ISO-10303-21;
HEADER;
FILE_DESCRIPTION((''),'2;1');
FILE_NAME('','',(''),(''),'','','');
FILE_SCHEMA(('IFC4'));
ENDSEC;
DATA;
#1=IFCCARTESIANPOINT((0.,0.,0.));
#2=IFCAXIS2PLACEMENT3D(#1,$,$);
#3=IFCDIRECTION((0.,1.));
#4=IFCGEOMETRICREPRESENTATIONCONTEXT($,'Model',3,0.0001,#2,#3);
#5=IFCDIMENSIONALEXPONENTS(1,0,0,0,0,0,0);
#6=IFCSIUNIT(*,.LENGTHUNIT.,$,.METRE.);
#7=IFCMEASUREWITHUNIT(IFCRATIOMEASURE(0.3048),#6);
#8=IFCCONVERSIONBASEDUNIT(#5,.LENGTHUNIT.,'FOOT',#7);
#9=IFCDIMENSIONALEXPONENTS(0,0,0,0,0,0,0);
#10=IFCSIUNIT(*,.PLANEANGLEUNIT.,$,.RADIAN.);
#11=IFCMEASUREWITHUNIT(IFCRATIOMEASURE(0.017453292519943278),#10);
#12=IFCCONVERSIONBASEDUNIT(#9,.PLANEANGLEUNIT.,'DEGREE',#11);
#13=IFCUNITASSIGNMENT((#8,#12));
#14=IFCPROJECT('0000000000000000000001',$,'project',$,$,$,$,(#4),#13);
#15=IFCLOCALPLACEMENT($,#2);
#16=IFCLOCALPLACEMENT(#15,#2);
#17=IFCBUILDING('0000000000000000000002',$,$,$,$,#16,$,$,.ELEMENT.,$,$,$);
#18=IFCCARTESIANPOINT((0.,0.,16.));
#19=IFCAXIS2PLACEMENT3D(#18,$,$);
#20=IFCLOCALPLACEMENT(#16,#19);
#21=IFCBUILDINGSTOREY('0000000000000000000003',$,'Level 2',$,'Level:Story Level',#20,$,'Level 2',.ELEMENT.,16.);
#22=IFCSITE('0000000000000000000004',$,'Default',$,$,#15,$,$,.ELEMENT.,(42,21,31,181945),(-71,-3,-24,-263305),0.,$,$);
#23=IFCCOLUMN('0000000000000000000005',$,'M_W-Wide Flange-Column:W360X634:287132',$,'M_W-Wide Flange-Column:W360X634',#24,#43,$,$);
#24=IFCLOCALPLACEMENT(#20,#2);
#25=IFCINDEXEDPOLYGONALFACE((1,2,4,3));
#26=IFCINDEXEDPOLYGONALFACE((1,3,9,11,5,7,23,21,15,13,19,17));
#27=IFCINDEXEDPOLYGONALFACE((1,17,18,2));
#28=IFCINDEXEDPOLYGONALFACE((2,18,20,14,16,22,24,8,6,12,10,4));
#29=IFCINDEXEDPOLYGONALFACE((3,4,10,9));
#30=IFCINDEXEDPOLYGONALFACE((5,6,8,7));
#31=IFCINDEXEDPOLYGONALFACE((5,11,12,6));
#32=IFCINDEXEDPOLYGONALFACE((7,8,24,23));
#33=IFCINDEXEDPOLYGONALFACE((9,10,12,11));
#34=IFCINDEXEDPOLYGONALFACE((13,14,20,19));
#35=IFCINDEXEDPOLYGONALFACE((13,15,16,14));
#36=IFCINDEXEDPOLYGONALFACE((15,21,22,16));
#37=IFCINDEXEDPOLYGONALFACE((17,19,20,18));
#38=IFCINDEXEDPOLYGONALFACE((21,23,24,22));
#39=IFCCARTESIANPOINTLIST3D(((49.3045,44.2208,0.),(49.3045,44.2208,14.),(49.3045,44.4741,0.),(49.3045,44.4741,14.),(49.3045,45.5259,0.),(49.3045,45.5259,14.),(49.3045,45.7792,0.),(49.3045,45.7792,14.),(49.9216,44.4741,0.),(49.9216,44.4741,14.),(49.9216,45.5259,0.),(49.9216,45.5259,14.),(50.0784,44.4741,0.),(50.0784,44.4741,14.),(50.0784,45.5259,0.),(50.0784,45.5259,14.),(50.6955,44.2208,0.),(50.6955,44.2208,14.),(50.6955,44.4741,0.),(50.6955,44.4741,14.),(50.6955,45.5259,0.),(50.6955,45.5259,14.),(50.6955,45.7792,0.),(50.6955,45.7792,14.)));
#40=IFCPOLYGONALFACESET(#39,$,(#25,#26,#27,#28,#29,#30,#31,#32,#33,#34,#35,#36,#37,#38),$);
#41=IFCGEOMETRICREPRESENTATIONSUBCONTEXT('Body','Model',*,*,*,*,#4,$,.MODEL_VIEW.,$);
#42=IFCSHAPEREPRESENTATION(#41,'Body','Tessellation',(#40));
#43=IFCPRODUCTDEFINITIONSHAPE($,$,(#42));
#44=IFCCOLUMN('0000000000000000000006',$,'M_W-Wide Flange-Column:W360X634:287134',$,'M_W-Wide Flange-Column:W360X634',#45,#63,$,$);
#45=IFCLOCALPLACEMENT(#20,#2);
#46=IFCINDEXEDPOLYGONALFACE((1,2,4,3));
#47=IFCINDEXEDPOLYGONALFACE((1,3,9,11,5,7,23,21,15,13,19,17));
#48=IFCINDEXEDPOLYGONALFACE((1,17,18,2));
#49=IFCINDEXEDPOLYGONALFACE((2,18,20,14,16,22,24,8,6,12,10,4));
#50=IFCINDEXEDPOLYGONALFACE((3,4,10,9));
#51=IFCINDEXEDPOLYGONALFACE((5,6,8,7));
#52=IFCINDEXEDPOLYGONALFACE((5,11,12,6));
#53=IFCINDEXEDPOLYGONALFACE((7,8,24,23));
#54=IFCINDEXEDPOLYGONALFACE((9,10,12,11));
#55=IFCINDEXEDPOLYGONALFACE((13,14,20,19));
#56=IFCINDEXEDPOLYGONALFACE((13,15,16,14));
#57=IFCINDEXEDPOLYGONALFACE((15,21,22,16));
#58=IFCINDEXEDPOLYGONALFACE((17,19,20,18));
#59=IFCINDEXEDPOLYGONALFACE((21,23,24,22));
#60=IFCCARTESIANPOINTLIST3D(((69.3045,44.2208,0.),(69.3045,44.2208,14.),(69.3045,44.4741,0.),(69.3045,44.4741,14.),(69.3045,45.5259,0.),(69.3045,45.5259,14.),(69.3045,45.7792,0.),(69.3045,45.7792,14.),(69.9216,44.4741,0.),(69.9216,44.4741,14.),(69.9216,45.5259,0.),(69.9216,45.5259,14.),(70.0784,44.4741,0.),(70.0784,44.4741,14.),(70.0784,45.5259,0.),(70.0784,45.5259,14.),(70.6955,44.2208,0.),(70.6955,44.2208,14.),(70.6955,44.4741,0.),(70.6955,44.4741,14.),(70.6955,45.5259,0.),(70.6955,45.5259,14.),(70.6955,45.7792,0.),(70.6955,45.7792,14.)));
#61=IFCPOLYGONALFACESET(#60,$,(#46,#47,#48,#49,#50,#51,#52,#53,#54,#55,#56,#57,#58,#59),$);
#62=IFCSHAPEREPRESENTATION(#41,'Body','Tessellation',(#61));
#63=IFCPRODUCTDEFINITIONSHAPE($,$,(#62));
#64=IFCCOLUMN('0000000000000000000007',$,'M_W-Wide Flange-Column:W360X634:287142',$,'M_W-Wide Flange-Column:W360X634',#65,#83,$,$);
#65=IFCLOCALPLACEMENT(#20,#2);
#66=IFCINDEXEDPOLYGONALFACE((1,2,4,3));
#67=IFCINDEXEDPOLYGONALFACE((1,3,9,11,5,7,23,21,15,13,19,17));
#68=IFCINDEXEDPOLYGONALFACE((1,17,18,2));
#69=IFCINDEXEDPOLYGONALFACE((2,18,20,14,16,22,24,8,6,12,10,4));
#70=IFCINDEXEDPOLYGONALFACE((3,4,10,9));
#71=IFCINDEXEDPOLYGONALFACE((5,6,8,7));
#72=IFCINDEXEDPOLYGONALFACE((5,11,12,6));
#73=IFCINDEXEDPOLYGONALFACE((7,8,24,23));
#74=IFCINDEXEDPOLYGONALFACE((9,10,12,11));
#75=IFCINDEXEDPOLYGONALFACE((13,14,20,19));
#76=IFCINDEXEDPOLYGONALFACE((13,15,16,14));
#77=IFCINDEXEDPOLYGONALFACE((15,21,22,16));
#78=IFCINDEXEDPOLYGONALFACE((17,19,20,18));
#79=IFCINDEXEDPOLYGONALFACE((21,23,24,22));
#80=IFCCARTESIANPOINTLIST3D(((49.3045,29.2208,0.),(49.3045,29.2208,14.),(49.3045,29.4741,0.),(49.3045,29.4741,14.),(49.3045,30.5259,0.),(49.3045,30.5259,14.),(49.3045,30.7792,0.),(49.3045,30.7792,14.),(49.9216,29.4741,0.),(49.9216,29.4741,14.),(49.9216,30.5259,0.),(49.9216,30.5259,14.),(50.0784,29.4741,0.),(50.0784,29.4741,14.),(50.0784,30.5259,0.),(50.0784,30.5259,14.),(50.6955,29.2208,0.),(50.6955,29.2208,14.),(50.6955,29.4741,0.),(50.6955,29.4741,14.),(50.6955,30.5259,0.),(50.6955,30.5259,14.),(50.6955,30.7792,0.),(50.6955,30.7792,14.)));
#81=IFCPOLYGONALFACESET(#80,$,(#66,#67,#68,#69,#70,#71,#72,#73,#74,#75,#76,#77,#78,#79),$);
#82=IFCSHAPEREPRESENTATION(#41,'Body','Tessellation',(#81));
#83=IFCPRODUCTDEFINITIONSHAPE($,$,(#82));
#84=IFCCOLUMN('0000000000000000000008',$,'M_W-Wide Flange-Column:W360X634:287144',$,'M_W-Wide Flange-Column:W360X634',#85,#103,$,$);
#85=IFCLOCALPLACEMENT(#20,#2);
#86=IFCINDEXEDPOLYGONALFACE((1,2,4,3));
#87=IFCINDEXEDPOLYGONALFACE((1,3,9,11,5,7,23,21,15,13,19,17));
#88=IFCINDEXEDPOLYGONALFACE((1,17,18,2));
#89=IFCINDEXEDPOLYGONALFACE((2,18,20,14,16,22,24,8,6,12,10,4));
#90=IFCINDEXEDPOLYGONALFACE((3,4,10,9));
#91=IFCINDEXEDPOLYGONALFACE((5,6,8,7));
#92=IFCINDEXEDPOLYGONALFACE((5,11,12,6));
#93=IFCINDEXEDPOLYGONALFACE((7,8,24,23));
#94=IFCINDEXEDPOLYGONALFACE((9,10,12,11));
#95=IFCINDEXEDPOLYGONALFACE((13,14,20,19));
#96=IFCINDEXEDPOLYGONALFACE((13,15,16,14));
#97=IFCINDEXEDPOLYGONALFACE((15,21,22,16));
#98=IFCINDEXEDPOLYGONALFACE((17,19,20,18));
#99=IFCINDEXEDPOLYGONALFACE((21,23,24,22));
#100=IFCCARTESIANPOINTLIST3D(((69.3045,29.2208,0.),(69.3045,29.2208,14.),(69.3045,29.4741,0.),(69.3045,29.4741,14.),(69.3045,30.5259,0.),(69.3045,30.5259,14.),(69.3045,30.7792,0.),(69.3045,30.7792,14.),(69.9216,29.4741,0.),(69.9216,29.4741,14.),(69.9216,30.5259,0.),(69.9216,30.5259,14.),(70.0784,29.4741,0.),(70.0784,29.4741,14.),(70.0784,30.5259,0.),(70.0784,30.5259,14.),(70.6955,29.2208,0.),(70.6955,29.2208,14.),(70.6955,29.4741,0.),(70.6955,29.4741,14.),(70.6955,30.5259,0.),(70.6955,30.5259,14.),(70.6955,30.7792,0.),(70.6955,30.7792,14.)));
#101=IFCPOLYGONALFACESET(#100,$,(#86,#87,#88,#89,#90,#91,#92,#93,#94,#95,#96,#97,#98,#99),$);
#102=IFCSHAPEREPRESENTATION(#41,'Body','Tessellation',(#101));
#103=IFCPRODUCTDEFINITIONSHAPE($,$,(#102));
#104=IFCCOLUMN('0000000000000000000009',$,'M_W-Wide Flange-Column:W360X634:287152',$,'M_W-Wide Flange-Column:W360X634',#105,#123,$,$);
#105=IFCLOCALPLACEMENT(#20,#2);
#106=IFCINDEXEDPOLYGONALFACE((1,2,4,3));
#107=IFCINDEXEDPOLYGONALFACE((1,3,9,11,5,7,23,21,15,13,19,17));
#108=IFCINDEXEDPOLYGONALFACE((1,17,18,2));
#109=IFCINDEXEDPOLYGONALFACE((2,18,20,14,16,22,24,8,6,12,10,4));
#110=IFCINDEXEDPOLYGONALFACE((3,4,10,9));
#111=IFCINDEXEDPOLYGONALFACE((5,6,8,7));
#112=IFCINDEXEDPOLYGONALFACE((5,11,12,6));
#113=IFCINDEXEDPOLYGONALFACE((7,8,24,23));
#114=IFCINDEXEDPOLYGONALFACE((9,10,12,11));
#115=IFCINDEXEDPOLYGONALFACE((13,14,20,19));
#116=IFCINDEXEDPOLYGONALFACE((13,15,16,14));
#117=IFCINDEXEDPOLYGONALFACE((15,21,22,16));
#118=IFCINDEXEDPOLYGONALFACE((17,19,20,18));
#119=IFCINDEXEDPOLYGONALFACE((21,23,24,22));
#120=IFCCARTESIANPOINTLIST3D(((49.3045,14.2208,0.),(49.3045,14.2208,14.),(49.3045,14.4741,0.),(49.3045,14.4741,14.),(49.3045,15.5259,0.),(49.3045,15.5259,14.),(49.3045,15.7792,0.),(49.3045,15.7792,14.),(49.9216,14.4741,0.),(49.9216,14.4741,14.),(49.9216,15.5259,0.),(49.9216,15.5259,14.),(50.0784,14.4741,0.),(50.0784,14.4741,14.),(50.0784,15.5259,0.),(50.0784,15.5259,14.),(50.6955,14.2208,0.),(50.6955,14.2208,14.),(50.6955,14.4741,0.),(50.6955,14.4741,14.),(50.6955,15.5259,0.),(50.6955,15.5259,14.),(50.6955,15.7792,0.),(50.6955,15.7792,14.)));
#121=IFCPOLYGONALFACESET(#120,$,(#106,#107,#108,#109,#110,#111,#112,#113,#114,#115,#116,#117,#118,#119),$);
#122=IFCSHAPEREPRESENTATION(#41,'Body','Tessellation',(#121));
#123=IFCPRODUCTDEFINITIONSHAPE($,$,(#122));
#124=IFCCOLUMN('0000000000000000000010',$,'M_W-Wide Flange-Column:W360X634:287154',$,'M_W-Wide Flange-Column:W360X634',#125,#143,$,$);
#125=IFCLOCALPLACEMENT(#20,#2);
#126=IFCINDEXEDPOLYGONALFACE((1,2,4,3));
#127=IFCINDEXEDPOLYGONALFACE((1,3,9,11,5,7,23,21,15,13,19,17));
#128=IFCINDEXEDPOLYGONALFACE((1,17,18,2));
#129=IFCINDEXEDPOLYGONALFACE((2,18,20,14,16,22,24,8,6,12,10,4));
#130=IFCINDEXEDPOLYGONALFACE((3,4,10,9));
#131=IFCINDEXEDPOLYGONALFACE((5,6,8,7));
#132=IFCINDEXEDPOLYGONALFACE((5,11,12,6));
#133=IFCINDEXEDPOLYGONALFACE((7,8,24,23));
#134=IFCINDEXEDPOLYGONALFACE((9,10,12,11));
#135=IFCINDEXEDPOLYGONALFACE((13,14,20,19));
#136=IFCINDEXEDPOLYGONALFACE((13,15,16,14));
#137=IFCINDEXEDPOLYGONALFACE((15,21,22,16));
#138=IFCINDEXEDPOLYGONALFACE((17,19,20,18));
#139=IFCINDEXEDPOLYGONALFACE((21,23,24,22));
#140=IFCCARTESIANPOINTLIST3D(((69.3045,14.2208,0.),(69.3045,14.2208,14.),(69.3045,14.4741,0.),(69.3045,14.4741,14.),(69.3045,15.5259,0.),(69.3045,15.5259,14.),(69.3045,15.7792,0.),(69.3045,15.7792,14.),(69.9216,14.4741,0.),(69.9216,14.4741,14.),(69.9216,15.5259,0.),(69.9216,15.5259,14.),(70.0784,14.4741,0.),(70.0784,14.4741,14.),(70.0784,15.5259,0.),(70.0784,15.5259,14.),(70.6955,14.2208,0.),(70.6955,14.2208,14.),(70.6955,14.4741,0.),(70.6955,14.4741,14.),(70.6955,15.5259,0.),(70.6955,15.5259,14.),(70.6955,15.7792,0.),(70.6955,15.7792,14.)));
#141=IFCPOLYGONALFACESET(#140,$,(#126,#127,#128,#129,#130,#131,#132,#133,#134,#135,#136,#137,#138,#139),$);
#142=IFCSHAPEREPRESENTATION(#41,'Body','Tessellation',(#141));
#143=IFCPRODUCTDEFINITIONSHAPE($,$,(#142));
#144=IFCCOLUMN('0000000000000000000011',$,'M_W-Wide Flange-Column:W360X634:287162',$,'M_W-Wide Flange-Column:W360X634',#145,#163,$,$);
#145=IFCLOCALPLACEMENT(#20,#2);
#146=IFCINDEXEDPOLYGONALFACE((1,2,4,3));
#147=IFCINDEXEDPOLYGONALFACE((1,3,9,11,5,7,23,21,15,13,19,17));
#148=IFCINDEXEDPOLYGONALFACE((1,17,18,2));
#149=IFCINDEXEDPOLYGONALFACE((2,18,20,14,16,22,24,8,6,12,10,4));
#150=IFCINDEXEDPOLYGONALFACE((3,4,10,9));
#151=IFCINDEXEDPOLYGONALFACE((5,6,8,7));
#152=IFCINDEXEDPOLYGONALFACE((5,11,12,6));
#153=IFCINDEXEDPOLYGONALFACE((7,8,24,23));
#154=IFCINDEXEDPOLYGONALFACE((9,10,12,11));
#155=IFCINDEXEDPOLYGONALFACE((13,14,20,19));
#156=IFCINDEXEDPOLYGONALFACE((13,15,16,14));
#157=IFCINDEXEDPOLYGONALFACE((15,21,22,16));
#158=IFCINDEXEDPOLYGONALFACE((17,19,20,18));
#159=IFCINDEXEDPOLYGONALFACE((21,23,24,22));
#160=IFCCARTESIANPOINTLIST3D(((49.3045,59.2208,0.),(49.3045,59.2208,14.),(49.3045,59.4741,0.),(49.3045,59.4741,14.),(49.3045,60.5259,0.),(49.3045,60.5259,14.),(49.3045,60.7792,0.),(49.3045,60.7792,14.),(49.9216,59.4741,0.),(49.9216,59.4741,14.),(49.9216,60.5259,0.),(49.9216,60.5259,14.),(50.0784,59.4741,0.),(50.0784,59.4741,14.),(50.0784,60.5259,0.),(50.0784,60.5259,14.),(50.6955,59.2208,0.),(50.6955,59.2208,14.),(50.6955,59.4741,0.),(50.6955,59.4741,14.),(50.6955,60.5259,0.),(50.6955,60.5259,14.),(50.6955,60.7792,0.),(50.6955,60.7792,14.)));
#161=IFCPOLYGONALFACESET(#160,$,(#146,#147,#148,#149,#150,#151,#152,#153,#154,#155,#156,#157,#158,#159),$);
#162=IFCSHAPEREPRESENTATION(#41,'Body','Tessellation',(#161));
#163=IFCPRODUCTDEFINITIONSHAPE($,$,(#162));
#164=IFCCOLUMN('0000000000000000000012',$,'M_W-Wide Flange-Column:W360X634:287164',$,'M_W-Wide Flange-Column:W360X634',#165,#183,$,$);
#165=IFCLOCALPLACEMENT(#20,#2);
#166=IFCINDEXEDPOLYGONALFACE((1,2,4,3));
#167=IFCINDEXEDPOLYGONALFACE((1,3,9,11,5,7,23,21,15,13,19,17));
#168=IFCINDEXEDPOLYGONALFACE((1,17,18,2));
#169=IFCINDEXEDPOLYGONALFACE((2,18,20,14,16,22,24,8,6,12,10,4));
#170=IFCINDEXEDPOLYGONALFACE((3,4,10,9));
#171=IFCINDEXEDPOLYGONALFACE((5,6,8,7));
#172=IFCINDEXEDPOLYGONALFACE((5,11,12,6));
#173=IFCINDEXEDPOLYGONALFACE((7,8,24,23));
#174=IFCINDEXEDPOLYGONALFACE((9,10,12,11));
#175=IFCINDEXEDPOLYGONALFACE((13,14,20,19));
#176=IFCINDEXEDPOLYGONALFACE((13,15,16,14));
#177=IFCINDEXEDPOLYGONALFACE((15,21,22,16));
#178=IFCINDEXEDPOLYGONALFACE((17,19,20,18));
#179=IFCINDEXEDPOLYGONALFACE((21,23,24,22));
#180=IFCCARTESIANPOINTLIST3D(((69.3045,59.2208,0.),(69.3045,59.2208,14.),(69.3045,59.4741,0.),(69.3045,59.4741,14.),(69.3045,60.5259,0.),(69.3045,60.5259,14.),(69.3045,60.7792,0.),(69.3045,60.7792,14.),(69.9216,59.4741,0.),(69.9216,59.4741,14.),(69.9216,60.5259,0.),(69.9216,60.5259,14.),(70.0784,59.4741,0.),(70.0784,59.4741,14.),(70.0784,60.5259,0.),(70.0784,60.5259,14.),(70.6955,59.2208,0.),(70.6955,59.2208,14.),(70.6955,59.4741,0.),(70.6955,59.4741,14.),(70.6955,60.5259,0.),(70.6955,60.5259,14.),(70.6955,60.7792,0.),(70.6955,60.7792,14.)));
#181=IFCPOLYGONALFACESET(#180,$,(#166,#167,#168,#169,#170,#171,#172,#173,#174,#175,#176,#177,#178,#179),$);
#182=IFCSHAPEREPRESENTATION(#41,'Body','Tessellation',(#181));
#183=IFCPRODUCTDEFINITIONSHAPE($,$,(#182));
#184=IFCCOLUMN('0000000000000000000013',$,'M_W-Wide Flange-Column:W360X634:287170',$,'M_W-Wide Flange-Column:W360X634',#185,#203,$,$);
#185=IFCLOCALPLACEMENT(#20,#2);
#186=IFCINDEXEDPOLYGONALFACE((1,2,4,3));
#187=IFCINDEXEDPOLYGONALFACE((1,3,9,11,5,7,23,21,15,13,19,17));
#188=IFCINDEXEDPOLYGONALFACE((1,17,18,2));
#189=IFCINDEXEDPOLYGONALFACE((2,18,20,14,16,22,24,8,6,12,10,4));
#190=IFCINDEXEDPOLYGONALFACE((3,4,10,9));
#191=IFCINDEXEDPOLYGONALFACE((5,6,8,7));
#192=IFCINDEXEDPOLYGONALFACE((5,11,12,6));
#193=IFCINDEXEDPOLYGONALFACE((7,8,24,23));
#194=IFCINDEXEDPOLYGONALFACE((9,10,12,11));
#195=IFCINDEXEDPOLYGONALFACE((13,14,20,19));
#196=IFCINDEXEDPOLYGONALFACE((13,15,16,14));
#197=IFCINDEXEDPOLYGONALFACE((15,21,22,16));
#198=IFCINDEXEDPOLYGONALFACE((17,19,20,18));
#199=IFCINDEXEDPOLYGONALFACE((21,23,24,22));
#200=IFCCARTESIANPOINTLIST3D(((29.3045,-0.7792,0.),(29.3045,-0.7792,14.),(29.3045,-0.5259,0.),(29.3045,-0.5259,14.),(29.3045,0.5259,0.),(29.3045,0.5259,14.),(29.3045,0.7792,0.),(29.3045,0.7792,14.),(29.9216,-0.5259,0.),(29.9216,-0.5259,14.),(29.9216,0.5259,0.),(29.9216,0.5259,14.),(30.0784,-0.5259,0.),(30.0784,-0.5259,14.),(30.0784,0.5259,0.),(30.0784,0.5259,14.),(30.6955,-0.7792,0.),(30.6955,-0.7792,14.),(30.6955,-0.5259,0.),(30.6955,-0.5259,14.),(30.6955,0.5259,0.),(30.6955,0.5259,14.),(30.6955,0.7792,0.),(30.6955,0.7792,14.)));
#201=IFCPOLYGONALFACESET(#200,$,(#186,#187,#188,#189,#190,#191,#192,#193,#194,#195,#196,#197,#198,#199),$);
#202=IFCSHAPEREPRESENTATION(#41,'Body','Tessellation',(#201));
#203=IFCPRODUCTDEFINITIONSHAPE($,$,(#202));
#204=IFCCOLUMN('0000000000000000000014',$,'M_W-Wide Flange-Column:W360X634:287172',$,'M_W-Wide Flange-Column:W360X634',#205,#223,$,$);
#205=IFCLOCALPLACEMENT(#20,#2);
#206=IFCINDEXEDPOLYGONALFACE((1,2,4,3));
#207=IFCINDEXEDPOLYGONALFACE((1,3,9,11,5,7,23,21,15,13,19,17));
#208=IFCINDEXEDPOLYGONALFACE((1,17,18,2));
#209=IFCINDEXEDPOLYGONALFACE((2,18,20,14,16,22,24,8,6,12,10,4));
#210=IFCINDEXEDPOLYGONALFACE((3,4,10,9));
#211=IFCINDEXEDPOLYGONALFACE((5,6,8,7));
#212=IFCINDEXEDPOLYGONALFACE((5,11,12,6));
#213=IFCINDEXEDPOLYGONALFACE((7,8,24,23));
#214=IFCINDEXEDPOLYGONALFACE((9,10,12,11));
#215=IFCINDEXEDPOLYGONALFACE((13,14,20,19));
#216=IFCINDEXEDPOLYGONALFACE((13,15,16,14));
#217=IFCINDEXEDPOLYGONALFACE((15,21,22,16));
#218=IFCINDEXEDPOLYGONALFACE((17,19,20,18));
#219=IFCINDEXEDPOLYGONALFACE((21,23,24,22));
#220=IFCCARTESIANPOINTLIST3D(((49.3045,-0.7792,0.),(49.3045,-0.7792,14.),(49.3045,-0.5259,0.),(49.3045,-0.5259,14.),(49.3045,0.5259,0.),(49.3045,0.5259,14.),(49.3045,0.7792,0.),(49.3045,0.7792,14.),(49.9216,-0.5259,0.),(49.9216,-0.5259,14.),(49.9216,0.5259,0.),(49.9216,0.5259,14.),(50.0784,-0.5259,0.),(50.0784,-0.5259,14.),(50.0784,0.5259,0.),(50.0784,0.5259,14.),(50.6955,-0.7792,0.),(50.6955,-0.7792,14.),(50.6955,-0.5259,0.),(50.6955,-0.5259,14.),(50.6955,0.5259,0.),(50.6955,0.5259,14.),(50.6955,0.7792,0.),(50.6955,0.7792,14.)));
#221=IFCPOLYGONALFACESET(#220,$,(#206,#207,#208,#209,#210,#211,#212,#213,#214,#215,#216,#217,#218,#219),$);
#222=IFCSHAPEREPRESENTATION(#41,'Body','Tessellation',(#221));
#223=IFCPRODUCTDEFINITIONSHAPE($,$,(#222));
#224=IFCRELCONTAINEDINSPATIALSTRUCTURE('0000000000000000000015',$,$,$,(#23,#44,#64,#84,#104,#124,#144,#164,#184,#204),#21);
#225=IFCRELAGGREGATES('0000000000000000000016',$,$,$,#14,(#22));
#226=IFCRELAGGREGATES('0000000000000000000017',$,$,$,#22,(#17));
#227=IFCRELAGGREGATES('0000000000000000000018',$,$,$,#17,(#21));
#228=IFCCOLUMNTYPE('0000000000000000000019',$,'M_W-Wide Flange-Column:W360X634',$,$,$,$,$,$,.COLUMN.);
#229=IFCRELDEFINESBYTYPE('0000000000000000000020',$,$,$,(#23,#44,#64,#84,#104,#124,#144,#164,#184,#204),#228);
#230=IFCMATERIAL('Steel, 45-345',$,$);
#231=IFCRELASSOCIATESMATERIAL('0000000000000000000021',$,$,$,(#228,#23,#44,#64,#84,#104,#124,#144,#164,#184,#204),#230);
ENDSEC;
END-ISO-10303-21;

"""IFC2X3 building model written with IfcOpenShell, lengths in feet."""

from ifc_helpers import new_model, entity, si_unit, converted_unit, direction, frame, origin, place, context, subcontext, project, spatial, polyline, outline, extrude, source, transform, mapped, material, type_object, type_shapes, element, save


model = new_model("IFC2X3")

# Units and contexts
model_context = context("Model", 3, precision=0.0001, world=origin(), true_north=direction((0.0, 1.0)))
body_context = subcontext(model_context, "Body", "Model", "MODEL_VIEW")
ifc_project = project(units=[converted_unit("LENGTHUNIT", "FOOT", entity("IfcRatioMeasure", 0.3048), si_unit("LENGTHUNIT", "METRE"), dimensions=[1, 0, 0, 0, 0, 0, 0]), converted_unit("PLANEANGLEUNIT", "DEGREE", entity("IfcRatioMeasure", 0.017453292519943278), si_unit("PLANEANGLEUNIT", "RADIAN"), dimensions=[0, 0, 0, 0, 0, 0, 0])], contexts=[model_context])

# Site, building, storey
site_placement = place(None, origin())
site = spatial("IfcSite", under=ifc_project, at=site_placement, Name="Default", CompositionType="ELEMENT", RefLatitude=(42, 21, 31, 181945), RefLongitude=(-71, -3, -24, -263305), RefElevation=0.0)
building_placement = place(site_placement, origin())
building = spatial("IfcBuilding", under=site, at=building_placement, CompositionType="ELEMENT")
storey_placement = place(building_placement, frame((0.0, 0.0, 16.0)))
storey = spatial("IfcBuildingStorey", under=building, at=storey_placement, Name="Level 2", ObjectType="Level:Story Level", LongName="Level 2", CompositionType="ELEMENT", Elevation=16.0)

# Columns
ifc_material = material(Name="Steel, 45-345")
column_type = type_object("IfcColumnType", Name="M_W-Wide Flange-Column:W360X634", PredefinedType="COLUMN", material=ifc_material)
shared_shape = source(origin(), body_context, "Body", "SweptSolid", [
    extrude(outline(polyline([(0.5259, -0.6955), (0.7792, -0.6955), (0.7792, 0.6955), (0.5259, 0.6955), (0.5259, 0.0784), (-0.5259, 0.0784), (-0.5259, 0.6955), (-0.7792, 0.6955), (-0.7792, -0.6955), (-0.5259, -0.6955), (-0.5259, -0.0784), (0.5259, -0.0784), (0.5259, -0.6955)])), frame((0.0, 0.0, 16.0), z_axis=(0.0, 0.0, 1.0), x_axis=(0.0, -1.0, 0.0)), (0.0, 0.0, 1.0), 14.0),
])
type_shapes(column_type, [shared_shape])
for number, where, name in (
    (1, (50.0, 45.0, -16.0), "M_W-Wide Flange-Column:W360X634:287132"),
    (2, (70.0, 45.0, -16.0), "M_W-Wide Flange-Column:W360X634:287134"),
    (3, (50.0, 30.0, -16.0), "M_W-Wide Flange-Column:W360X634:287142"),
    (4, (70.0, 30.0, -16.0), "M_W-Wide Flange-Column:W360X634:287144"),
    (5, (50.0, 15.0, -16.0), "M_W-Wide Flange-Column:W360X634:287152"),
    (6, (70.0, 15.0, -16.0), "M_W-Wide Flange-Column:W360X634:287154"),
    (7, (50.0, 60.0, -16.0), "M_W-Wide Flange-Column:W360X634:287162"),
    (8, (70.0, 60.0, -16.0), "M_W-Wide Flange-Column:W360X634:287164"),
    (9, (30.0, 0.0, -16.0), "M_W-Wide Flange-Column:W360X634:287170"),
    (10, (50.0, 0.0, -16.0), "M_W-Wide Flange-Column:W360X634:287172"),
):
    element("IfcColumn", number, at=place(storey_placement, frame(where)), inside=storey, type_object=column_type, material=ifc_material, Name=name, ObjectType="M_W-Wide Flange-Column:W360X634", context=body_context, shape_type="MappedRepresentation", body=[
        mapped(shared_shape, transform((0.0, 0.0, 0.0), scale=1.0)),
    ])

save(model, "model.ifc")
